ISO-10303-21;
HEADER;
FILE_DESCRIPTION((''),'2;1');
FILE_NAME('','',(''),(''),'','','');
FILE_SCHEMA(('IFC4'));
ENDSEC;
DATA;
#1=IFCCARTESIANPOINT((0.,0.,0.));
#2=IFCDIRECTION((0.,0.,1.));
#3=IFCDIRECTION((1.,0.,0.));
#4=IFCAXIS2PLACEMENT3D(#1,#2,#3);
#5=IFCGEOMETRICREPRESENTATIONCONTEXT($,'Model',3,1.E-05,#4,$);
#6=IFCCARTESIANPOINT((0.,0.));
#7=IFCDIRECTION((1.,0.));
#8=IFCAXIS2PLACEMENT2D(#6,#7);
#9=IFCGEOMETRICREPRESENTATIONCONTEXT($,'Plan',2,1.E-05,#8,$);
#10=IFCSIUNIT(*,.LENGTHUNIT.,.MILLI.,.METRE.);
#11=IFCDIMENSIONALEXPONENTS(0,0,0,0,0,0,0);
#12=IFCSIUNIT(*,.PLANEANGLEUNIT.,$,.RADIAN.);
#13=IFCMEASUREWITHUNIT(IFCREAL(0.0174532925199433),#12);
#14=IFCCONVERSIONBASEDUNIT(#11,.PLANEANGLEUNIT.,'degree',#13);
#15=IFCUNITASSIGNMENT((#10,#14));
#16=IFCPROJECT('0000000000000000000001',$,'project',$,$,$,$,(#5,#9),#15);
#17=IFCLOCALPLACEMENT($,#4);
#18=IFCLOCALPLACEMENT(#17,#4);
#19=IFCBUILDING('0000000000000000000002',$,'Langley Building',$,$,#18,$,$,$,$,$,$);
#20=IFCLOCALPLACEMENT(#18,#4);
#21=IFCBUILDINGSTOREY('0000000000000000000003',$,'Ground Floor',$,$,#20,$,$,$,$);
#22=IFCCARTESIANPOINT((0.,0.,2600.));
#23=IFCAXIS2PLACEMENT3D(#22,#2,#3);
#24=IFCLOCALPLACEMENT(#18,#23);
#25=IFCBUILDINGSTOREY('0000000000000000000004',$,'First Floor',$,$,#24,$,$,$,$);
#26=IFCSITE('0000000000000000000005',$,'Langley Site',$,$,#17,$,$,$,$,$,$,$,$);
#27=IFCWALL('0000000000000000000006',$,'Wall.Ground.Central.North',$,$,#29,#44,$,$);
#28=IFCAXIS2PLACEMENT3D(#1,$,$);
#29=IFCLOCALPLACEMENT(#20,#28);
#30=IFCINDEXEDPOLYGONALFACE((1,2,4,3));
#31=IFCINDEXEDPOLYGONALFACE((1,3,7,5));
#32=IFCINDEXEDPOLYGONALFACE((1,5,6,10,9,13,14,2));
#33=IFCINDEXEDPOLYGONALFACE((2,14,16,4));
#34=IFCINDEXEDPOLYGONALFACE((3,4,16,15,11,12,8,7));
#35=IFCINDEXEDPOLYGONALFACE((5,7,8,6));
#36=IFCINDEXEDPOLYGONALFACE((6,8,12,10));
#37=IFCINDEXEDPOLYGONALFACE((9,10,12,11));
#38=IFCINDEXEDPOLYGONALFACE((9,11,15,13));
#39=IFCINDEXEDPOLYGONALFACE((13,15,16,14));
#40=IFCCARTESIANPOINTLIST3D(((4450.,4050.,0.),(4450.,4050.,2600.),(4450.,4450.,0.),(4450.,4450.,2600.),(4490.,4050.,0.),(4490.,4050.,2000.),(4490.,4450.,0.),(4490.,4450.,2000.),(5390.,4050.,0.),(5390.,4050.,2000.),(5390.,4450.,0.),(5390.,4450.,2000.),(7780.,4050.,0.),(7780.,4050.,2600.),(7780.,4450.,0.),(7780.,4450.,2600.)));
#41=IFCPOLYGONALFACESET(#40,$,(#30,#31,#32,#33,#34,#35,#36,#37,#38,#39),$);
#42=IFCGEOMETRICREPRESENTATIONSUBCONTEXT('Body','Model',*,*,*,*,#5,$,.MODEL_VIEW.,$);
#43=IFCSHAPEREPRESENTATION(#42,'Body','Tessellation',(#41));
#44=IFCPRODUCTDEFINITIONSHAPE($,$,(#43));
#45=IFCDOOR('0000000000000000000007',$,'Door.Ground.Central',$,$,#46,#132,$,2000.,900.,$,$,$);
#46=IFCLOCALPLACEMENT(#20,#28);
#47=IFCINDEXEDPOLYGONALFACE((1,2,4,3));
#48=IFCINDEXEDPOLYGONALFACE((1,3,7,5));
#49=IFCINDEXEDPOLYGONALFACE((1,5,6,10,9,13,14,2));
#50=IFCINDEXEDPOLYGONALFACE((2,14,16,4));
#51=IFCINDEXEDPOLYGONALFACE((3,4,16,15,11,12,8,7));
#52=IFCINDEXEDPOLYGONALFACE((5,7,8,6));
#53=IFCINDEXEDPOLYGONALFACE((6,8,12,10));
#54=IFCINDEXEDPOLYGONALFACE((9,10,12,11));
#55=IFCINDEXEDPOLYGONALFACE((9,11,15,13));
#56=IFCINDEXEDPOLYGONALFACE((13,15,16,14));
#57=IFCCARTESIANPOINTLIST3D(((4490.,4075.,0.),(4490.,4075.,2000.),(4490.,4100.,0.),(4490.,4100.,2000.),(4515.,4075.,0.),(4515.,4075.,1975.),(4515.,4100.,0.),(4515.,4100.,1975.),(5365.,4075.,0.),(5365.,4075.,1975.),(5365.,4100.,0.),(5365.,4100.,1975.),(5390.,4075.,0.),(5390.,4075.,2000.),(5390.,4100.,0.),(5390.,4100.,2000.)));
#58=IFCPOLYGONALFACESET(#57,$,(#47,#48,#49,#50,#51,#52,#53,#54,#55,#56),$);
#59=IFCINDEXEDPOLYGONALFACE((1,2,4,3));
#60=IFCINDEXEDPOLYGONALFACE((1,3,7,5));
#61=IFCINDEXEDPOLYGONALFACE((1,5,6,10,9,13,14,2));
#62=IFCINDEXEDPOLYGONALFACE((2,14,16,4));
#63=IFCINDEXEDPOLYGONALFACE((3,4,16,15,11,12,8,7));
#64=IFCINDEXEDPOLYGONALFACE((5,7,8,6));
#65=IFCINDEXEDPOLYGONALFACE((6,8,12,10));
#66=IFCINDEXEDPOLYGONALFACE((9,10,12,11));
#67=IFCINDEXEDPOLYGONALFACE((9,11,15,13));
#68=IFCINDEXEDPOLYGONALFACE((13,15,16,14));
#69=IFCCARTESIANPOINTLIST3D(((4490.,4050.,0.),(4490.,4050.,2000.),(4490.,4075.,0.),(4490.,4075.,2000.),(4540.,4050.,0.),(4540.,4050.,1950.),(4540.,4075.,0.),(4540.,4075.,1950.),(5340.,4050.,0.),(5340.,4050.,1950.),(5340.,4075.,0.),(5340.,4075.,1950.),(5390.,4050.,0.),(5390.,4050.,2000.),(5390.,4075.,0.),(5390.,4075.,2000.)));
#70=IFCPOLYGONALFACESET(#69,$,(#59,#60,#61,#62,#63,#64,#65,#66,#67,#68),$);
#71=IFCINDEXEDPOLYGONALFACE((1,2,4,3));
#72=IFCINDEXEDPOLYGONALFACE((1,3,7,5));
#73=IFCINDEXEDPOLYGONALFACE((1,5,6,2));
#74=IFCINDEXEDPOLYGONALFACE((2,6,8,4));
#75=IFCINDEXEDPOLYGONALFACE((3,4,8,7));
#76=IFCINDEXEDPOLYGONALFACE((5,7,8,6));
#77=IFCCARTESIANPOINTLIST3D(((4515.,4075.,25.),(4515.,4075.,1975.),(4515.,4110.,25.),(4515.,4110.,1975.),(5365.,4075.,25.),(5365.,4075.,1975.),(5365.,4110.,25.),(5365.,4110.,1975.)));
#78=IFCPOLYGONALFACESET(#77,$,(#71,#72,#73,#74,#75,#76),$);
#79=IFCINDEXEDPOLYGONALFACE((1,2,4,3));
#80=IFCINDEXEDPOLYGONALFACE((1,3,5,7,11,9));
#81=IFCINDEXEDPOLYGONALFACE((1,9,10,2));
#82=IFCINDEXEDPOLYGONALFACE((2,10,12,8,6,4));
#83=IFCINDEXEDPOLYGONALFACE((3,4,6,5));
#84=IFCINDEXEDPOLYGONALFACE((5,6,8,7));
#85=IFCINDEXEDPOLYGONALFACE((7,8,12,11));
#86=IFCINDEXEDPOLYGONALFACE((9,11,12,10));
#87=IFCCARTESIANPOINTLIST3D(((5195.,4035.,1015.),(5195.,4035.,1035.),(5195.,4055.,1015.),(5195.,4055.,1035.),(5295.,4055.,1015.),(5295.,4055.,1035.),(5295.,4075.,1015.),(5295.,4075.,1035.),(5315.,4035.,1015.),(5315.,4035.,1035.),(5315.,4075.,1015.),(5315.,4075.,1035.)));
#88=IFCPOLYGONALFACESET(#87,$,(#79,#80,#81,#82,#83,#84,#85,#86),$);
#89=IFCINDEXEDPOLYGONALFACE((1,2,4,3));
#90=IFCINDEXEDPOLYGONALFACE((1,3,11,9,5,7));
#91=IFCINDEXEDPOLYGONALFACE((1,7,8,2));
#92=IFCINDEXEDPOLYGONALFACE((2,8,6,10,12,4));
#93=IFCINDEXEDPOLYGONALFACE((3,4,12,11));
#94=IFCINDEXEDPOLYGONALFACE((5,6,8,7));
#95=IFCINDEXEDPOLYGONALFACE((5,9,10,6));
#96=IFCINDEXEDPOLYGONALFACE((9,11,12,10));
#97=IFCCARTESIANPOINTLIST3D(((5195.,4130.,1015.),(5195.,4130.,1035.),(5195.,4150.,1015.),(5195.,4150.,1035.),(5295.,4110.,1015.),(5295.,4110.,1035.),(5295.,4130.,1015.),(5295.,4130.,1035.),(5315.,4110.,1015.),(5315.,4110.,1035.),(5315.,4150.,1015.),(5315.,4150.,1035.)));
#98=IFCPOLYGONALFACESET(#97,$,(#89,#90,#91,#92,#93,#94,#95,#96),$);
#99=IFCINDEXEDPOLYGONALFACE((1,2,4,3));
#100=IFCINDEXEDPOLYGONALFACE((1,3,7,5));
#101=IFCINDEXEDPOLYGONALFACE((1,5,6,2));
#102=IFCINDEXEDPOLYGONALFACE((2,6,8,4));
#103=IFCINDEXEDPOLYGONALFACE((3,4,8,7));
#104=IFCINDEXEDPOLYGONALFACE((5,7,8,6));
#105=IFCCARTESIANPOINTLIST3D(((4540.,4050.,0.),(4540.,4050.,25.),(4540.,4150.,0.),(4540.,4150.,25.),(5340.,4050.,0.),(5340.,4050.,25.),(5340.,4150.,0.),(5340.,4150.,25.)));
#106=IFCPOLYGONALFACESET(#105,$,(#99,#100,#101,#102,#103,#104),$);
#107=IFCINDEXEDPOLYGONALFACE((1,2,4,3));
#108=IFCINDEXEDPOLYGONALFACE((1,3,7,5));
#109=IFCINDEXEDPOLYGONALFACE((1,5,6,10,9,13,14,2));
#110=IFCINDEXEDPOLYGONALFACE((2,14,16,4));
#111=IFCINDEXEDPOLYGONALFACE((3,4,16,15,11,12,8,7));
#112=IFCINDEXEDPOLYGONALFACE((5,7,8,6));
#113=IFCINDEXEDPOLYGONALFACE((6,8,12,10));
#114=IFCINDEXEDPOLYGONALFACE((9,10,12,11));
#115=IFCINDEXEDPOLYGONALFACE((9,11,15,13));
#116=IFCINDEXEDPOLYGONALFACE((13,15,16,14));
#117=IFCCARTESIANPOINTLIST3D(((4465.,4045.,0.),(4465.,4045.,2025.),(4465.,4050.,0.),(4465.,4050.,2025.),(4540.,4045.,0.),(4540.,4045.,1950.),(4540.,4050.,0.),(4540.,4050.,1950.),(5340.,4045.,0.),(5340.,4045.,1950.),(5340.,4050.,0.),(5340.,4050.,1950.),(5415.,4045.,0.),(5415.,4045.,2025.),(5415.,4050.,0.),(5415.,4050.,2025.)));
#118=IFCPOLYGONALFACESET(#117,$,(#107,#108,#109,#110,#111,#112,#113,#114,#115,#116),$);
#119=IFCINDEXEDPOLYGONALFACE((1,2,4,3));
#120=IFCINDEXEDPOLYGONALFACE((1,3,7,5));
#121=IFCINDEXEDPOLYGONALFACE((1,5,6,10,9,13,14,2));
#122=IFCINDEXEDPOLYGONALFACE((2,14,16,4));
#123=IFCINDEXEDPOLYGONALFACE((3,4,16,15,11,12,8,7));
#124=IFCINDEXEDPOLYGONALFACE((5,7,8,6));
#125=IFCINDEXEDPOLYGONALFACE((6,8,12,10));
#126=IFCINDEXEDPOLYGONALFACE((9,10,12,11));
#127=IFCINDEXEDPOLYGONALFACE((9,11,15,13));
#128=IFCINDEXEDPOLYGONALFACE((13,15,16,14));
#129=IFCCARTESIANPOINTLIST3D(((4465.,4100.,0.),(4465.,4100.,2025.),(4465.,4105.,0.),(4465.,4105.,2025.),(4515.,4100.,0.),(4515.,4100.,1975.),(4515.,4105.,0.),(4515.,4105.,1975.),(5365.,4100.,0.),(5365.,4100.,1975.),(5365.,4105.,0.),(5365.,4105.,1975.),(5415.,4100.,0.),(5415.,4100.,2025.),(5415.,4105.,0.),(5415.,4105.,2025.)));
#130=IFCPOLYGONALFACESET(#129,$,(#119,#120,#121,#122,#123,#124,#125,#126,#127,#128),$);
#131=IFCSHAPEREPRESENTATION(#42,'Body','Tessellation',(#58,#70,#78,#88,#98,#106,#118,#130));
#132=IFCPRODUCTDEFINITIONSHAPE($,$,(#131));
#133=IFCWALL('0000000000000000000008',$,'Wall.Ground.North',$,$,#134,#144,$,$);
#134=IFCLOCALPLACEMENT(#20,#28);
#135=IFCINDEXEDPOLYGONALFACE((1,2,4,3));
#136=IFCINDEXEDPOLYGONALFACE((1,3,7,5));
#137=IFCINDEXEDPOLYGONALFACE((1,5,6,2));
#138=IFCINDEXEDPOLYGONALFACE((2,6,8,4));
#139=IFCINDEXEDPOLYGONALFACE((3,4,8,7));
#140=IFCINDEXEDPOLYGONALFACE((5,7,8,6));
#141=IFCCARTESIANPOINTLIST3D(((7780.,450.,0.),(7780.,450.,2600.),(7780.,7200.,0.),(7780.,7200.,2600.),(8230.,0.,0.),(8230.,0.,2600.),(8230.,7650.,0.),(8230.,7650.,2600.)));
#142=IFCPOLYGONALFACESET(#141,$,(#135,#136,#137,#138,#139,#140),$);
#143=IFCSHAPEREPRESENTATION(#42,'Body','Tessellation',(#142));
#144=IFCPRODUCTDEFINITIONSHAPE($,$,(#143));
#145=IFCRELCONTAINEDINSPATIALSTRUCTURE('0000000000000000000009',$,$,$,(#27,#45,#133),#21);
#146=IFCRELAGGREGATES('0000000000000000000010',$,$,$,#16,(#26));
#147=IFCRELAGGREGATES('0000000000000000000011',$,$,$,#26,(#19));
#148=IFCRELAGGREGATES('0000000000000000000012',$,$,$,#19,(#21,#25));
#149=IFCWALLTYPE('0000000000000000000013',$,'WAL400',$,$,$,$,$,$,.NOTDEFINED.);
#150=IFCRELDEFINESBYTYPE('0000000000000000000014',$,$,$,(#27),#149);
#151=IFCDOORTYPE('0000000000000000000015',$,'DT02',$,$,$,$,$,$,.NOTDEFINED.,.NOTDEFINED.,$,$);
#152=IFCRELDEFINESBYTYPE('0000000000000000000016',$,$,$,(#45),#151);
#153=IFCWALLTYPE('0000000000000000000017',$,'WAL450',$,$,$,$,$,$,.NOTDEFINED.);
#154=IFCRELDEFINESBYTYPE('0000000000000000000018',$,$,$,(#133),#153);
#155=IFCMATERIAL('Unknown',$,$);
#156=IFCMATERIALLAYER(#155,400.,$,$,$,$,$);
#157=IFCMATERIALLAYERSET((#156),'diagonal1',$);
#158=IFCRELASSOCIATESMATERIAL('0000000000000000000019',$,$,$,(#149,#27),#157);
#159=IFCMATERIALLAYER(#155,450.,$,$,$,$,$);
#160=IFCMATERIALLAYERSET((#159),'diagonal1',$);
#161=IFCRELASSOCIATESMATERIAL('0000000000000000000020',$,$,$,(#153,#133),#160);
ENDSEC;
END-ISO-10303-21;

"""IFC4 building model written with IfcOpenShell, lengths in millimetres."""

from ifc_helpers import new_model, entity, si_unit, converted_unit, frame, origin_with_axes, origin_2d_with_axis, place, context, subcontext, project, spatial, line, indexed_curve, outline, extrude, shape, source, transform, mapped, material, layer, layer_set, layer_usage, type_object, type_shapes, element, fill, save


model = new_model("IFC4")

# Units and contexts
model_context = context("Model", 3, precision=1e-05, world=origin_with_axes())
plan_context = context("Plan", 2, precision=1e-05, world=origin_2d_with_axis())
body_context_1 = subcontext(model_context, "Body", "Model", "MODEL_VIEW")
body_context_2 = subcontext(plan_context, "Body", "Plan", "PLAN_VIEW")
ifc_project = project(units=[si_unit("LENGTHUNIT", "METRE", prefix="MILLI"), converted_unit("PLANEANGLEUNIT", "degree", entity("IfcReal", 0.0174532925199433), si_unit("PLANEANGLEUNIT", "RADIAN"), dimensions=[0, 0, 0, 0, 0, 0, 0])], contexts=[model_context, plan_context])

# Site, building, storey
site_placement = place(None, origin_with_axes())
site = spatial("IfcSite", under=ifc_project, at=site_placement, Name="Langley Site")
building_placement = place(site_placement, origin_with_axes())
building = spatial("IfcBuilding", under=site, at=building_placement, Name="Langley Building")
storey_1_placement = place(building_placement, origin_with_axes())
storey_1 = spatial("IfcBuildingStorey", under=building, at=storey_1_placement, Name="Ground Floor")

# Shared definitions
ifc_material = material(Name="Unknown")

# Shared definitions
shared_shape_1 = source(origin_with_axes(), body_context_1, "Body", "SweptSolid", [
    extrude(outline(indexed_curve([(0.0, 0.0), (900.0, 0.0), (900.0, 2000.0), (0.0, 2000.0)], segments=[line(1, 2, 3, 4, 1)])), frame((0.0, -600.0, 0.0), z_axis=(0.0, -1.0, 0.0), x_axis=(1.0, 0.0, 0.0)), (0.0, 0.0, -1.0), 1200.0),
])

# Shared definitions
storey_2_placement = place(building_placement, frame((0.0, 0.0, 2600.0), z_axis=(0.0, 0.0, 1.0), x_axis=(1.0, 0.0, 0.0)))
storey_2 = spatial("IfcBuildingStorey", under=building, at=storey_2_placement, Name="First Floor")

# Shared definitions
door_type_1 = type_object("IfcDoorType", Name="DT02", OperationType="NOTDEFINED", PredefinedType="NOTDEFINED")
shared_shape_2 = source(origin_with_axes(), body_context_1, "Body", "SweptSolid", [
    extrude(outline(indexed_curve([(0.0, 0.0), (0.0, 2000.0), (900.0, 2000.0), (900.0, 0.0), (875.0, 0.0), (875.0, 1975.0), (25.0, 1975.0), (25.0, 0.0)], segments=[line(1, 2, 3, 4, 5, 6, 7, 8, 1)])), frame((0.0, 25.0, 0.0), z_axis=(0.0, -1.0, 0.0), x_axis=(1.0, 0.0, 0.0)), (0.0, 0.0, -1.0), 25.0),
    extrude(outline(indexed_curve([(0.0, 0.0), (0.0, 2000.0), (900.0, 2000.0), (900.0, 0.0), (850.0, 0.0), (850.0, 1950.0), (50.0, 1950.0), (50.0, 0.0)], segments=[line(1, 2, 3, 4, 5, 6, 7, 8, 1)])), frame((0.0, 0.0, 0.0), z_axis=(0.0, -1.0, 0.0), x_axis=(1.0, 0.0, 0.0)), (0.0, 0.0, -1.0), 25.0),
    extrude(outline(indexed_curve([(0.0, 0.0), (850.0, 0.0), (850.0, 35.0), (0.0, 35.0)], segments=[line(1, 2, 3, 4, 1)])), frame((25.0, 25.0, 25.0), z_axis=(0.0, 0.0, 1.0), x_axis=(1.0, 0.0, 0.0)), (0.0, 0.0, 1.0), 1950.0),
    extrude(outline(indexed_curve([(0.0, 0.0), (0.0, -40.0), (-120.0, -40.0), (-120.0, -20.0), (-20.0, -20.0), (-20.0, 0.0)], segments=[line(1, 2, 3, 4, 5, 6, 1)])), frame((825.0, 25.0, 1015.0), z_axis=(0.0, 0.0, 1.0), x_axis=(1.0, 0.0, 0.0)), (0.0, 0.0, 1.0), 20.0),
    extrude(outline(indexed_curve([(0.0, 0.0), (0.0, 40.0), (-120.0, 40.0), (-120.0, 20.0), (-20.0, 20.0), (-20.0, 0.0)], segments=[line(1, 2, 3, 4, 5, 6, 1)])), frame((825.0, 60.0, 1015.0), z_axis=(0.0, 0.0, 1.0), x_axis=(1.0, 0.0, 0.0)), (0.0, 0.0, 1.0), 20.0),
    extrude(outline(indexed_curve([(0.0, 0.0), (800.0, 0.0), (800.0, 100.0), (0.0, 100.0)], segments=[line(1, 2, 3, 4, 1)])), frame((50.0, 0.0, 0.0), z_axis=(0.0, 0.0, 1.0), x_axis=(1.0, 0.0, 0.0)), (0.0, 0.0, 1.0), 25.0),
    extrude(outline(indexed_curve([(0.0, 0.0), (0.0, 2025.0), (950.0, 2025.0), (950.0, 0.0), (875.0, 0.0), (875.0, 1950.0), (75.0, 1950.0), (75.0, 0.0)], segments=[line(1, 2, 3, 4, 5, 6, 7, 8, 1)])), frame((-25.0, -5.0, 0.0), z_axis=(0.0, -1.0, 0.0), x_axis=(1.0, 0.0, 0.0)), (0.0, 0.0, -1.0), 5.0),
    extrude(outline(indexed_curve([(0.0, 0.0), (0.0, 2025.0), (950.0, 2025.0), (950.0, 0.0), (900.0, 0.0), (900.0, 1975.0), (50.0, 1975.0), (50.0, 0.0)], segments=[line(1, 2, 3, 4, 5, 6, 7, 8, 1)])), frame((-25.0, 50.0, 0.0), z_axis=(0.0, -1.0, 0.0), x_axis=(1.0, 0.0, 0.0)), (0.0, 0.0, -1.0), 5.0),
])
shared_shape_3 = source(origin_with_axes(), body_context_2, "Body", "Curve2D", [
    entity("IfcIndexedPolyCurve", entity("IfcCartesianPointList2D", [[0.0, 0.0], [0.0, 50.0], [25.0, 50.0], [25.0, 25.0], [50.0, 25.0], [50.0, 0.0]]), [entity("IfcLineIndex", [1, 2, 3, 4, 5, 6, 1])]),
    entity("IfcIndexedPolyCurve", entity("IfcCartesianPointList2D", [[900.0, 0.0], [900.0, 50.0], [875.0, 50.0], [875.0, 25.0], [850.0, 25.0], [850.0, 0.0]]), [entity("IfcLineIndex", [1, 2, 3, 4, 5, 6, 1])]),
    entity("IfcTrimmedCurve", entity("IfcEllipse", entity("IfcAxis2Placement2D", entity("IfcCartesianPoint", [60.0, 50.0]), entity("IfcDirection", [1.0, 0.0])), 815.0, 850.0), [entity("IfcCartesianPoint", [875.0, 50.0])], [entity("IfcCartesianPoint", [60.0, 900.0])], True, "CARTESIAN"),
    entity("IfcIndexedPolyCurve", entity("IfcCartesianPointList2D", [[25.0, 50.0], [60.0, 50.0], [60.0, 900.0], [25.0, 900.0]]), [entity("IfcLineIndex", [1, 2, 3, 4, 1])]),
])
type_shapes(door_type_1, [shared_shape_2, shared_shape_3])

# Wall, opening, door
ifc_layer_1 = layer(ifc_material, 400.0)
ifc_layer_set_1 = layer_set([ifc_layer_1], Name="diagonal1")
ifc_layer_usage_1 = layer_usage(ifc_layer_set_1, "AXIS2", "POSITIVE", 0.0)
wall_type_1 = type_object("IfcWallType", Name="WAL400", PredefinedType="NOTDEFINED", material=ifc_layer_set_1)
wall_1_placement = place(storey_1_placement, frame((4450.0, 4050.0, 0.0), z_axis=(0.0, 0.0, 1.0), x_axis=(1.0, 0.0, 0.0)))
wall_1 = element("IfcWall", 1, at=wall_1_placement, inside=storey_1, type_object=wall_type_1, material=ifc_layer_usage_1, Name="Wall.Ground.Central.North", context=body_context_1, shape_type="SweptSolid", body=[
    extrude(outline(indexed_curve([(0.0, 0.0), (0.0, 400.0), (3330.0, 400.0), (3330.0, 0.0)], segments=[line(1, 2, 3, 4, 1)])), origin_with_axes(), (0.0, 0.0, 1.0), 2600.0),
])
opening_1_placement = place(wall_1_placement, frame((40.0, 0.0, 0.0), z_axis=(0.0, 0.0, 1.0), x_axis=(1.0, 0.0, 0.0)))
opening_1 = element("IfcOpeningElement", 2, at=opening_1_placement, cuts=wall_1, PredefinedType="OPENING", context=body_context_1, shape_type="MappedRepresentation", body=[
    mapped(shared_shape_1, transform((0.0, 0.0, 0.0), x_axis=(1.0, 0.0, 0.0), y_axis=(0.0, 1.0, 0.0), z_axis=(0.0, 0.0, 1.0), scale=1.0)),
])
door_1_placement = place(opening_1_placement, frame((0.0, 0.0, 0.0), z_axis=(0.0, 0.0, 1.0), x_axis=(1.0, 0.0, 0.0)))
door_1 = element("IfcDoor", 3, at=door_1_placement, inside=storey_1, type_object=door_type_1, Name="Door.Ground.Central", OverallHeight=2000.0, OverallWidth=900.0, shapes=[
    shape(body_context_1, "Body", "MappedRepresentation", [mapped(shared_shape_2, transform((0.0, 0.0, 0.0), x_axis=(1.0, 0.0, 0.0), y_axis=(0.0, 1.0, 0.0), z_axis=(0.0, 0.0, 1.0), scale=1.0))]),
    shape(body_context_2, "Body", "MappedRepresentation", [mapped(shared_shape_3, transform((0.0, 0.0, 0.0), x_axis=(1.0, 0.0, 0.0), y_axis=(0.0, 1.0, 0.0), z_axis=(0.0, 0.0, 1.0), scale=1.0))]),
])
fill(opening_1, door_1)

# Wall
ifc_layer_2 = layer(ifc_material, 450.0)
ifc_layer_set_2 = layer_set([ifc_layer_2], Name="diagonal1")
ifc_layer_usage_2 = layer_usage(ifc_layer_set_2, "AXIS2", "POSITIVE", 0.0)
wall_type_2 = type_object("IfcWallType", Name="WAL450", PredefinedType="NOTDEFINED", material=ifc_layer_set_2)
wall_2_placement = place(storey_1_placement, frame((8230.0, 0.0, 0.0), z_axis=(0.0, 0.0, 1.0), x_axis=(0.0, 1.0, 0.0)))
element("IfcWall", 4, at=wall_2_placement, inside=storey_1, type_object=wall_type_2, material=ifc_layer_usage_2, Name="Wall.Ground.North", context=body_context_1, shape_type="SweptSolid", body=[
    extrude(outline(indexed_curve([(0.0, 0.0), (450.0, 450.0), (7200.0, 450.0), (7650.0, 0.0)], segments=[line(1, 2, 3, 4, 1)])), origin_with_axes(), (0.0, 0.0, 1.0), 2600.0),
])

save(model, "model.ifc")
